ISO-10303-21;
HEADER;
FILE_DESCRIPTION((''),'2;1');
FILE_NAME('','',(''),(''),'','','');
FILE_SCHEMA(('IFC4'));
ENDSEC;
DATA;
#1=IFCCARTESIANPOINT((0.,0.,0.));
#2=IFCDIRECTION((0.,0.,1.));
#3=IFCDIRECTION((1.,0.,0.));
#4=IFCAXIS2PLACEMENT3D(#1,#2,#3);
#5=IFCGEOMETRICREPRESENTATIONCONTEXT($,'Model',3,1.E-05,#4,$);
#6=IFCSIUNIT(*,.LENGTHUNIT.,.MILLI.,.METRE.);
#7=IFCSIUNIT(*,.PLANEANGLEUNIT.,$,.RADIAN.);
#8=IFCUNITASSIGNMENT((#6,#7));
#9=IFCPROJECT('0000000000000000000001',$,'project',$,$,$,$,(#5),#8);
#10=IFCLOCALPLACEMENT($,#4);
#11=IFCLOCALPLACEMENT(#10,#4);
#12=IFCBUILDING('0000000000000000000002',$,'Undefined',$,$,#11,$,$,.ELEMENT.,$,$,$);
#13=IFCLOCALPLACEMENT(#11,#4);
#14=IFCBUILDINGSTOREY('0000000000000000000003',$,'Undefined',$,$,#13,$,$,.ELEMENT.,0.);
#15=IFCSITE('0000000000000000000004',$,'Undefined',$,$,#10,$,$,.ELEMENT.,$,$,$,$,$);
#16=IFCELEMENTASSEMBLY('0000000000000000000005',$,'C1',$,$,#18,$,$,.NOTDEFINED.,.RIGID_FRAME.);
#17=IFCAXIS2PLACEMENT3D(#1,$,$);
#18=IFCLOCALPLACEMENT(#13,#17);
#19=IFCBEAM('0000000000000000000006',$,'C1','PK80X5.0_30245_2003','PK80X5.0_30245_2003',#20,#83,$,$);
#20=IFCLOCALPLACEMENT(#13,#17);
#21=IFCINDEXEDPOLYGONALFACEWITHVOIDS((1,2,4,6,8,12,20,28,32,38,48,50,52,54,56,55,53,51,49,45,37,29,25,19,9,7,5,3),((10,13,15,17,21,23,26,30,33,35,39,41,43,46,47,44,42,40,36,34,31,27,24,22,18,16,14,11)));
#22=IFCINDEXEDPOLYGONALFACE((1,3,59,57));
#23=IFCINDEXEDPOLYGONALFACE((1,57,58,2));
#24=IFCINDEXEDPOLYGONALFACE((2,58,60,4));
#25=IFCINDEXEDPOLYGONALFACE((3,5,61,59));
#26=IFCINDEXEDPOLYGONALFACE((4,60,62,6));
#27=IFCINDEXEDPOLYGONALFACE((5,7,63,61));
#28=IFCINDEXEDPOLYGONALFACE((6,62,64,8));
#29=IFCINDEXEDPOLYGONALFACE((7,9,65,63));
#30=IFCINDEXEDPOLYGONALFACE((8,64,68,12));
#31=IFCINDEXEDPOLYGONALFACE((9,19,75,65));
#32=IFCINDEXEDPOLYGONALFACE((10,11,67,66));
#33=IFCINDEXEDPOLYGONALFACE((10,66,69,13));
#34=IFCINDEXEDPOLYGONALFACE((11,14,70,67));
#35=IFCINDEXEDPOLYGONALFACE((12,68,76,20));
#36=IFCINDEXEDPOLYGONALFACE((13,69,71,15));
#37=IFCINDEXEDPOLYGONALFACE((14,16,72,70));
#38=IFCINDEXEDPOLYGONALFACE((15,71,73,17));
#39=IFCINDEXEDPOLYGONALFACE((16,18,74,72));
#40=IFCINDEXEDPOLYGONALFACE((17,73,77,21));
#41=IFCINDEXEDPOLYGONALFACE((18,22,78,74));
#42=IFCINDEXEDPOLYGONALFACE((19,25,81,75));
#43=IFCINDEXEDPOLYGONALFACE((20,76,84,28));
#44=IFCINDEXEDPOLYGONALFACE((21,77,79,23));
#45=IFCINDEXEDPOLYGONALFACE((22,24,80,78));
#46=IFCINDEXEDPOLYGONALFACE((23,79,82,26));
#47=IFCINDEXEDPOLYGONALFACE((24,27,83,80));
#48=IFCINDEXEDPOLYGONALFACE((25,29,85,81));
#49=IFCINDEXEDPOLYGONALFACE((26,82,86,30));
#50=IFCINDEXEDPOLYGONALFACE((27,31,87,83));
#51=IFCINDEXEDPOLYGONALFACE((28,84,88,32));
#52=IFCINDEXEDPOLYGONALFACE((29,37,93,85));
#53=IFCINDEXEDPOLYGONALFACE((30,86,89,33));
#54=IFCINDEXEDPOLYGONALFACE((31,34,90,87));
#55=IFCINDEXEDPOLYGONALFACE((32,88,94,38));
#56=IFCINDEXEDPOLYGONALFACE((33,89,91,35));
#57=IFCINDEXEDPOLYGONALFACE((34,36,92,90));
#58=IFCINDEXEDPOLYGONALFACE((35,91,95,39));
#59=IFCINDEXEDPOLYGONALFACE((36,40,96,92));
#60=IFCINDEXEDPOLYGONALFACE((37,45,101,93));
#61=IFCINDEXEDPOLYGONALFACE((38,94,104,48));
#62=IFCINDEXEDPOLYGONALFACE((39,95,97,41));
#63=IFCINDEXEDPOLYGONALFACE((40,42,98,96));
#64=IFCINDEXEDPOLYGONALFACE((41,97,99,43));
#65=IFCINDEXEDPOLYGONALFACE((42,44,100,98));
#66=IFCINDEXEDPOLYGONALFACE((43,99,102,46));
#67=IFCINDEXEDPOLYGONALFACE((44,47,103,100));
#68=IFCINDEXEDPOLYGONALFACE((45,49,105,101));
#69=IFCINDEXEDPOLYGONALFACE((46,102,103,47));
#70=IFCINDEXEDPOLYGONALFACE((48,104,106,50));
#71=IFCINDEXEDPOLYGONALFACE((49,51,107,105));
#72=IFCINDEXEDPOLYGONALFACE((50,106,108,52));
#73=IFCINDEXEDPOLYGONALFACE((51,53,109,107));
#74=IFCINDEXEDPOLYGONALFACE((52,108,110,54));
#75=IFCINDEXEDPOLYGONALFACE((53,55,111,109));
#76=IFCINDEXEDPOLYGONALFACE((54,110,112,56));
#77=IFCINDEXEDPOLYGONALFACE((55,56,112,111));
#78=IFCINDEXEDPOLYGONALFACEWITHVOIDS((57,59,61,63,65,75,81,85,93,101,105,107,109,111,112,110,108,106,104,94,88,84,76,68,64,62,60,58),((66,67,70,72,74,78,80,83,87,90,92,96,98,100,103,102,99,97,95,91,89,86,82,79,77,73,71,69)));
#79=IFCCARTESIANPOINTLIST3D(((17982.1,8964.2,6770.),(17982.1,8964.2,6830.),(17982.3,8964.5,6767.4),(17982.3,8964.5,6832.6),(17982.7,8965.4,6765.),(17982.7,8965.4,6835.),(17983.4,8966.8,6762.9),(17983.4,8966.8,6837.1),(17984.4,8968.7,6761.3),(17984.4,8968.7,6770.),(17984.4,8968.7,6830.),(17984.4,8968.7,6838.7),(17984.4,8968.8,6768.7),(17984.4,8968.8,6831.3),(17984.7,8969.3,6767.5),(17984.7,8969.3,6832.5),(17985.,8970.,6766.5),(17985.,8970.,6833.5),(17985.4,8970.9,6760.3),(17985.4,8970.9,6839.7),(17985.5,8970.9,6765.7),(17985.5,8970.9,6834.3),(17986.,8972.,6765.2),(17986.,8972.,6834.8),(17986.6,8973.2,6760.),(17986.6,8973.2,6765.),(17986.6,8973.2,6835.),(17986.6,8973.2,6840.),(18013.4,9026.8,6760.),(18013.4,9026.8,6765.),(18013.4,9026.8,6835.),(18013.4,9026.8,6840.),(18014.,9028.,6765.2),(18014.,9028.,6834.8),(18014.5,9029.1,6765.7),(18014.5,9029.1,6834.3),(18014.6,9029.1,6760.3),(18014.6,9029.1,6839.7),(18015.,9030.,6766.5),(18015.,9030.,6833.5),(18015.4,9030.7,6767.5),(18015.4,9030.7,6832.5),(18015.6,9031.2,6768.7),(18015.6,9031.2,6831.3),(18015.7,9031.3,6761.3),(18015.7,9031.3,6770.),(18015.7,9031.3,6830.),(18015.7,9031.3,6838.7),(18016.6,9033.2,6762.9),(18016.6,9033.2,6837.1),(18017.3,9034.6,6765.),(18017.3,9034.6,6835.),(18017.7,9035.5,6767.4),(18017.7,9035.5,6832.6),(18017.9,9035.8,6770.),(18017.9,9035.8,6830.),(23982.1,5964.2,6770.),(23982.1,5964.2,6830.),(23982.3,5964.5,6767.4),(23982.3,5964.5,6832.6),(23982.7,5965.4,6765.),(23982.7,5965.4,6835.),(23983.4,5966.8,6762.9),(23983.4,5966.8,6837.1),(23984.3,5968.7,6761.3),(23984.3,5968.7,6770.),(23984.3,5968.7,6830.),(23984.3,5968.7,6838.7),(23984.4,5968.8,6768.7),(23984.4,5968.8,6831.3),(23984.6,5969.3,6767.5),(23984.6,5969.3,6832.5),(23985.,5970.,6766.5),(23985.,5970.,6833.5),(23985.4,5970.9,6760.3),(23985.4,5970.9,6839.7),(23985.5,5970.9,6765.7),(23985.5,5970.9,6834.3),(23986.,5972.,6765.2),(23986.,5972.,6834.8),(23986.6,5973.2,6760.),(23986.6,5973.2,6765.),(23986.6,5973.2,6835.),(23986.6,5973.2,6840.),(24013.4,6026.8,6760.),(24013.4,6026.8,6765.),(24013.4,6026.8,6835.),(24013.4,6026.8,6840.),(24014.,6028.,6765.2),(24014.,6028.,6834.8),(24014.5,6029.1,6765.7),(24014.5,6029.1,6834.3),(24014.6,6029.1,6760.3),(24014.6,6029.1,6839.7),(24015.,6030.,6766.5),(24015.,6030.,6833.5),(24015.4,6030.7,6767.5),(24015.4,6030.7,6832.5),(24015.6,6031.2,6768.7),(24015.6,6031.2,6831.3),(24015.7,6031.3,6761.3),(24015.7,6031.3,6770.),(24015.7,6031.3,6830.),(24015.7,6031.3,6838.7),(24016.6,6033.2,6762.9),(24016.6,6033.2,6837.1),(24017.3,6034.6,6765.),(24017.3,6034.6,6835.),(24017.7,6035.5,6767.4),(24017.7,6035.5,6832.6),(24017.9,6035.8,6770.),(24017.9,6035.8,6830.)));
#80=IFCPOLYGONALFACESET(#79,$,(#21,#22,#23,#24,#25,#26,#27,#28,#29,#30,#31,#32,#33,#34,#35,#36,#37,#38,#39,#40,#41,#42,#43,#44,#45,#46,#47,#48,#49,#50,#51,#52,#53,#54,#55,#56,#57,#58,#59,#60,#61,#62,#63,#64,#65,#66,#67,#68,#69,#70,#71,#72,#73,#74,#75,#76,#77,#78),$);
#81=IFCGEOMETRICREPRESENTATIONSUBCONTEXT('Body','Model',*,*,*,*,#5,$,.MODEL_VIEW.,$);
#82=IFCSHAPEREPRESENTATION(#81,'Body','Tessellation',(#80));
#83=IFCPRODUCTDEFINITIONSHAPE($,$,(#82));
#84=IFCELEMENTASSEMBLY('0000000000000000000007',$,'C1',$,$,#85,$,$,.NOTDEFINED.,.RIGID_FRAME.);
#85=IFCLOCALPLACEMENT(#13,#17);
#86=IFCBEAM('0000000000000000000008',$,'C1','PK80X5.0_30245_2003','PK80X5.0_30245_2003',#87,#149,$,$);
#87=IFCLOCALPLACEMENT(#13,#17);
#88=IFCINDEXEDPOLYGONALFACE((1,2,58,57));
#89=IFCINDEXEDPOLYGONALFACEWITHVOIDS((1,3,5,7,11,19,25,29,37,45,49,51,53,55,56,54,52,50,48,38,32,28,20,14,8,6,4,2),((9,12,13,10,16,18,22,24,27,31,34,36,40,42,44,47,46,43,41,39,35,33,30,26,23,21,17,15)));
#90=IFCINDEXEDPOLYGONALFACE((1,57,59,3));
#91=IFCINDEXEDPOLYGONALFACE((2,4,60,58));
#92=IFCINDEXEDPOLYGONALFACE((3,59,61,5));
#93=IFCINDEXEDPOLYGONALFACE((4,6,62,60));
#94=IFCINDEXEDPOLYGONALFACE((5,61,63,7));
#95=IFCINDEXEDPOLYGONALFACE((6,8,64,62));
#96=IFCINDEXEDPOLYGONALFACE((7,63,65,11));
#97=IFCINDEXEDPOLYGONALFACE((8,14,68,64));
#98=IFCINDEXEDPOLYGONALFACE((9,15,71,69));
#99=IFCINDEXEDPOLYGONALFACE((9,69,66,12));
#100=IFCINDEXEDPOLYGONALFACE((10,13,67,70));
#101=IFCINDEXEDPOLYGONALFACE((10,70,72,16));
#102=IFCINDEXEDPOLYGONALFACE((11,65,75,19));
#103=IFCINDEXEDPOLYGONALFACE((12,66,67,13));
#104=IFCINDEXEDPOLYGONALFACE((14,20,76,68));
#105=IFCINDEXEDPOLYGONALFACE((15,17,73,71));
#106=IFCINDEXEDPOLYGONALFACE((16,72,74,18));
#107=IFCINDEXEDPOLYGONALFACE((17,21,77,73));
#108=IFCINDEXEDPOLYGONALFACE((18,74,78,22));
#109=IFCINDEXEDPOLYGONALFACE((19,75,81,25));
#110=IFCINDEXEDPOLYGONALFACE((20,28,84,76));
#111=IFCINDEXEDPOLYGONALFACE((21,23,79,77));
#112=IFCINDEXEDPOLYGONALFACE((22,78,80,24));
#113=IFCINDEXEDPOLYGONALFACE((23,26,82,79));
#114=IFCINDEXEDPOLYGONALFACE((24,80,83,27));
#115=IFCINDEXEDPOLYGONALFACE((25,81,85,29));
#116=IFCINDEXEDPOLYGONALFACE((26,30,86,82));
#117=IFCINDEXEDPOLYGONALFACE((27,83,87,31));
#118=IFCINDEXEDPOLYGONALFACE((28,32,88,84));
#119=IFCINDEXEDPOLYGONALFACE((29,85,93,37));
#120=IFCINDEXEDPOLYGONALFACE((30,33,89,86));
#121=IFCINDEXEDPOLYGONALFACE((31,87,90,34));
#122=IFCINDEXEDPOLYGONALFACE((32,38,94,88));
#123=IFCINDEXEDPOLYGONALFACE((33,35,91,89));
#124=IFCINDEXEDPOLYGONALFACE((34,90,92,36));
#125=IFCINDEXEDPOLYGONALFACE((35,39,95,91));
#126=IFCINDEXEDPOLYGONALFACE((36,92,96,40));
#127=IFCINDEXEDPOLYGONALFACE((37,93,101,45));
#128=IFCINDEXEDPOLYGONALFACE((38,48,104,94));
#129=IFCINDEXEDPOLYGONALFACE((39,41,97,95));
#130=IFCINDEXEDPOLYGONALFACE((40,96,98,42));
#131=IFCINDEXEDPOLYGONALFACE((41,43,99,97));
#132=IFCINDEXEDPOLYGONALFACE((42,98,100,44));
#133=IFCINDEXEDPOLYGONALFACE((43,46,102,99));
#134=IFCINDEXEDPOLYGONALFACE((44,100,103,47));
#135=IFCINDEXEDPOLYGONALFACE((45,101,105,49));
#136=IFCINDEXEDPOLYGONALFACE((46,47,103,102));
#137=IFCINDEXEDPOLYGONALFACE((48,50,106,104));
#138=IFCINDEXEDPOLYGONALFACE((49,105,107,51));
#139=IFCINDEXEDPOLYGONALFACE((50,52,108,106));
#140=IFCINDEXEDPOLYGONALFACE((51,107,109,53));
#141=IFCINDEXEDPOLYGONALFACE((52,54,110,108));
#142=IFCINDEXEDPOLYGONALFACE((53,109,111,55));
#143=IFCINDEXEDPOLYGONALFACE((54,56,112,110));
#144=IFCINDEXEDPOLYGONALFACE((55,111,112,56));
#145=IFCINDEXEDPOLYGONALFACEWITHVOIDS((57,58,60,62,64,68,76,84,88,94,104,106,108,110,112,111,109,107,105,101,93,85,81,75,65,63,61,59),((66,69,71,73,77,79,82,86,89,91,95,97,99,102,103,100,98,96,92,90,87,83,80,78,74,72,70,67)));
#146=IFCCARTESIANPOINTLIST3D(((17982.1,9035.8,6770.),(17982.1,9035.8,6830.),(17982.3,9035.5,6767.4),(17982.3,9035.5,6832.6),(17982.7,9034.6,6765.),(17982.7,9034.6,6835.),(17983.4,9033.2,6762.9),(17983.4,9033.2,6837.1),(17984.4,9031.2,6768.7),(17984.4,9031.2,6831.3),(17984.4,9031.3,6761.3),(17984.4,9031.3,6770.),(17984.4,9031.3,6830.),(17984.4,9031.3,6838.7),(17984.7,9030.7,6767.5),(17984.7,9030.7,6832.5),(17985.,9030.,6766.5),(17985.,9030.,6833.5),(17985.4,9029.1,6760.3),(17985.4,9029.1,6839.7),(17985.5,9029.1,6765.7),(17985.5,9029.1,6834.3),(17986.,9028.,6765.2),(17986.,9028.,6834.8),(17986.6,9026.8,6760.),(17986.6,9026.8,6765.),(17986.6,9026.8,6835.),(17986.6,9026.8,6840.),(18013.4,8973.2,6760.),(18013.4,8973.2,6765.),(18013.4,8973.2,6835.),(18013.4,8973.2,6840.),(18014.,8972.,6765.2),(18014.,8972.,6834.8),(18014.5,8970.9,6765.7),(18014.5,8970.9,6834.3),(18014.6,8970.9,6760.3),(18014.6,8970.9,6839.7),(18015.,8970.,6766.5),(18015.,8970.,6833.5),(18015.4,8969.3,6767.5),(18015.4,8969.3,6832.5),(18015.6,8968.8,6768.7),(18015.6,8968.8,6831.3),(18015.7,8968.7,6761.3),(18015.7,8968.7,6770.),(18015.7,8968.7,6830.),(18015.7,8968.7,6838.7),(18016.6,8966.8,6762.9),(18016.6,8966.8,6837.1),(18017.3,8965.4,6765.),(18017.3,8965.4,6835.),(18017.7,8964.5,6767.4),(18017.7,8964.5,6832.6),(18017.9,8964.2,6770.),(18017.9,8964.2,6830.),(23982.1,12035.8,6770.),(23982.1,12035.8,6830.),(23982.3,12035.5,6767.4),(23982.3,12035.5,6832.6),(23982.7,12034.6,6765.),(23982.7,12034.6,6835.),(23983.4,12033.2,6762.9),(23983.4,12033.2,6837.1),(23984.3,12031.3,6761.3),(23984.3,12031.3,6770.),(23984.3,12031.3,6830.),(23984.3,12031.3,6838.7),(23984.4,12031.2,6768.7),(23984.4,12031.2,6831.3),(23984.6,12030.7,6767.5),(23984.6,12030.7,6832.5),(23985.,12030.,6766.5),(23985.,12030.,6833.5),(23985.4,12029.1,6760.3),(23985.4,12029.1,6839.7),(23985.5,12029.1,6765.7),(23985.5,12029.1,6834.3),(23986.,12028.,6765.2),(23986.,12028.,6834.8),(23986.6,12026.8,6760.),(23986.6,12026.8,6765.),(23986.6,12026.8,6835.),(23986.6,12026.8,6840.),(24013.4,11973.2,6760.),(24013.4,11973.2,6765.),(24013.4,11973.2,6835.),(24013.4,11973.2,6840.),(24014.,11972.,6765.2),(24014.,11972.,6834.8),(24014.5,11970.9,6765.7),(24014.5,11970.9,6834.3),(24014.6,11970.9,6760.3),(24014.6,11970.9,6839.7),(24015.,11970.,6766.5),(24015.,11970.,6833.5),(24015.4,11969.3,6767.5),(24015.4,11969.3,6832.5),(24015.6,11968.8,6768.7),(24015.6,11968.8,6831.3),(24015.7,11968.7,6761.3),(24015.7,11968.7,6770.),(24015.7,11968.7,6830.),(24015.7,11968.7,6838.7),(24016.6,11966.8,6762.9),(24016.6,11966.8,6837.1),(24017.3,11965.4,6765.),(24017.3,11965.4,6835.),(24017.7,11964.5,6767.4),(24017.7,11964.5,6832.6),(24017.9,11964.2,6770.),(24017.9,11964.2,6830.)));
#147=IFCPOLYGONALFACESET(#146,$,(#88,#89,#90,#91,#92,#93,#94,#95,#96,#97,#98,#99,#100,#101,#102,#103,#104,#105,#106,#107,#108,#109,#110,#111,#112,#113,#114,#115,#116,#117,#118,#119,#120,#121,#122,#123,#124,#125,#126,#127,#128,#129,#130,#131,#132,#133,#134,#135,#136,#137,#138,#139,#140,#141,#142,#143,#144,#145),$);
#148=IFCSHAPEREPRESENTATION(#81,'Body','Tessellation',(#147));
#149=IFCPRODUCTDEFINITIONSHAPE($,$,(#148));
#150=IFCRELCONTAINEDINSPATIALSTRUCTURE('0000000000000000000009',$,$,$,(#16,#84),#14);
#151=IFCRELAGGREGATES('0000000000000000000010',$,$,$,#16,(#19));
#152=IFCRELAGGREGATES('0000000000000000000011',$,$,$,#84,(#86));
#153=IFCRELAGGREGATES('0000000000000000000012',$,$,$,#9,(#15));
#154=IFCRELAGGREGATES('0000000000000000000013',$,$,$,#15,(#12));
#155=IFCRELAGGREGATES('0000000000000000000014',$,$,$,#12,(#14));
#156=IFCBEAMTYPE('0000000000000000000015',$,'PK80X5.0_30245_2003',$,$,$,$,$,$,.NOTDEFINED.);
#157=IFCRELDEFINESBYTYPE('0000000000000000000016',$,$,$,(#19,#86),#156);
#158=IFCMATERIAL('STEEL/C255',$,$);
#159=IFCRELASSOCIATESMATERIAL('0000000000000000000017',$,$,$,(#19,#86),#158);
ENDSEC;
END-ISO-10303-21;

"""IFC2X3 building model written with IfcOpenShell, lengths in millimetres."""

from ifc_helpers import new_model, si_unit, frame, origin_with_axes, origin_2d_with_axis, place, context, subcontext, project, spatial, hollow_rectangle, extrude, material, type_object, element, aggregate, save


model = new_model("IFC2X3")

# Units and contexts
model_context = context("Model", 3, precision=1e-05, world=origin_with_axes())
body_context = subcontext(model_context, "Body", "Model", "MODEL_VIEW")
ifc_project = project(units=[si_unit("LENGTHUNIT", "METRE", prefix="MILLI"), si_unit("PLANEANGLEUNIT", "RADIAN")], contexts=[model_context])

# Site, building, storey
site_placement = place(None, origin_with_axes())
site = spatial("IfcSite", under=ifc_project, at=site_placement, Name="Undefined", CompositionType="ELEMENT")
building_placement = place(site_placement, origin_with_axes())
building = spatial("IfcBuilding", under=site, at=building_placement, Name="Undefined", CompositionType="ELEMENT")
storey_placement = place(building_placement, origin_with_axes())
storey = spatial("IfcBuildingStorey", under=building, at=storey_placement, Name="Undefined", CompositionType="ELEMENT", Elevation=0.0)

# Element assemblies, beams
assembly_1_placement = place(storey_placement, origin_with_axes())
assembly_1 = element("IfcElementAssembly", 1, at=assembly_1_placement, inside=storey, Name="C1", AssemblyPlace="NOTDEFINED", PredefinedType="RIGID_FRAME")
ifc_material_1 = material(Name="STEEL/C255")
beam_type_1 = type_object("IfcBeamType", Name="PK80X5.0_30245_2003", PredefinedType="NOTDEFINED")
beam_1_placement = place(assembly_1_placement, frame((18000.0, 9000.0, 6800.0), z_axis=(0.0, 0.0, -1.0), x_axis=(0.894427, -0.447214, 0.0)))
beam_1 = element("IfcBeam", 2, at=beam_1_placement, type_object=beam_type_1, material=ifc_material_1, Name="C1", Description="PK80X5.0_30245_2003", ObjectType="PK80X5.0_30245_2003", context=body_context, shape_type="SweptSolid", body=[
    extrude(hollow_rectangle(XDim=80.0, YDim=80.0, WallThickness=5.0, InnerFilletRadius=5.0, OuterFilletRadius=10.0, at=origin_2d_with_axis()), frame((6708.2, 0.0, 0.0), z_axis=(-1.0, 0.0, 0.0), x_axis=(0.0, -1.0, 0.0)), (0.0, 0.0, 1.0), 6708.2),
])
aggregate(assembly_1, [beam_1])
assembly_2_placement = place(storey_placement, origin_with_axes())
assembly_2 = element("IfcElementAssembly", 3, at=assembly_2_placement, inside=storey, Name="C1", AssemblyPlace="NOTDEFINED", PredefinedType="RIGID_FRAME")
beam_2_placement = place(assembly_2_placement, frame((18000.0, 9000.0, 6800.0), z_axis=(0.0, 0.0, -1.0), x_axis=(0.894427, 0.447214, 0.0)))
beam_2 = element("IfcBeam", 4, at=beam_2_placement, type_object=beam_type_1, material=ifc_material_1, Name="C1", Description="PK80X5.0_30245_2003", ObjectType="PK80X5.0_30245_2003", context=body_context, shape_type="SweptSolid", body=[
    extrude(hollow_rectangle(XDim=80.0, YDim=80.0, WallThickness=5.0, InnerFilletRadius=5.0, OuterFilletRadius=10.0, at=origin_2d_with_axis()), frame((6708.2, 0.0, 0.0), z_axis=(-1.0, 0.0, 0.0), x_axis=(0.0, -1.0, 0.0)), (0.0, 0.0, 1.0), 6708.2),
])
aggregate(assembly_2, [beam_2])

save(model, "model.ifc")
